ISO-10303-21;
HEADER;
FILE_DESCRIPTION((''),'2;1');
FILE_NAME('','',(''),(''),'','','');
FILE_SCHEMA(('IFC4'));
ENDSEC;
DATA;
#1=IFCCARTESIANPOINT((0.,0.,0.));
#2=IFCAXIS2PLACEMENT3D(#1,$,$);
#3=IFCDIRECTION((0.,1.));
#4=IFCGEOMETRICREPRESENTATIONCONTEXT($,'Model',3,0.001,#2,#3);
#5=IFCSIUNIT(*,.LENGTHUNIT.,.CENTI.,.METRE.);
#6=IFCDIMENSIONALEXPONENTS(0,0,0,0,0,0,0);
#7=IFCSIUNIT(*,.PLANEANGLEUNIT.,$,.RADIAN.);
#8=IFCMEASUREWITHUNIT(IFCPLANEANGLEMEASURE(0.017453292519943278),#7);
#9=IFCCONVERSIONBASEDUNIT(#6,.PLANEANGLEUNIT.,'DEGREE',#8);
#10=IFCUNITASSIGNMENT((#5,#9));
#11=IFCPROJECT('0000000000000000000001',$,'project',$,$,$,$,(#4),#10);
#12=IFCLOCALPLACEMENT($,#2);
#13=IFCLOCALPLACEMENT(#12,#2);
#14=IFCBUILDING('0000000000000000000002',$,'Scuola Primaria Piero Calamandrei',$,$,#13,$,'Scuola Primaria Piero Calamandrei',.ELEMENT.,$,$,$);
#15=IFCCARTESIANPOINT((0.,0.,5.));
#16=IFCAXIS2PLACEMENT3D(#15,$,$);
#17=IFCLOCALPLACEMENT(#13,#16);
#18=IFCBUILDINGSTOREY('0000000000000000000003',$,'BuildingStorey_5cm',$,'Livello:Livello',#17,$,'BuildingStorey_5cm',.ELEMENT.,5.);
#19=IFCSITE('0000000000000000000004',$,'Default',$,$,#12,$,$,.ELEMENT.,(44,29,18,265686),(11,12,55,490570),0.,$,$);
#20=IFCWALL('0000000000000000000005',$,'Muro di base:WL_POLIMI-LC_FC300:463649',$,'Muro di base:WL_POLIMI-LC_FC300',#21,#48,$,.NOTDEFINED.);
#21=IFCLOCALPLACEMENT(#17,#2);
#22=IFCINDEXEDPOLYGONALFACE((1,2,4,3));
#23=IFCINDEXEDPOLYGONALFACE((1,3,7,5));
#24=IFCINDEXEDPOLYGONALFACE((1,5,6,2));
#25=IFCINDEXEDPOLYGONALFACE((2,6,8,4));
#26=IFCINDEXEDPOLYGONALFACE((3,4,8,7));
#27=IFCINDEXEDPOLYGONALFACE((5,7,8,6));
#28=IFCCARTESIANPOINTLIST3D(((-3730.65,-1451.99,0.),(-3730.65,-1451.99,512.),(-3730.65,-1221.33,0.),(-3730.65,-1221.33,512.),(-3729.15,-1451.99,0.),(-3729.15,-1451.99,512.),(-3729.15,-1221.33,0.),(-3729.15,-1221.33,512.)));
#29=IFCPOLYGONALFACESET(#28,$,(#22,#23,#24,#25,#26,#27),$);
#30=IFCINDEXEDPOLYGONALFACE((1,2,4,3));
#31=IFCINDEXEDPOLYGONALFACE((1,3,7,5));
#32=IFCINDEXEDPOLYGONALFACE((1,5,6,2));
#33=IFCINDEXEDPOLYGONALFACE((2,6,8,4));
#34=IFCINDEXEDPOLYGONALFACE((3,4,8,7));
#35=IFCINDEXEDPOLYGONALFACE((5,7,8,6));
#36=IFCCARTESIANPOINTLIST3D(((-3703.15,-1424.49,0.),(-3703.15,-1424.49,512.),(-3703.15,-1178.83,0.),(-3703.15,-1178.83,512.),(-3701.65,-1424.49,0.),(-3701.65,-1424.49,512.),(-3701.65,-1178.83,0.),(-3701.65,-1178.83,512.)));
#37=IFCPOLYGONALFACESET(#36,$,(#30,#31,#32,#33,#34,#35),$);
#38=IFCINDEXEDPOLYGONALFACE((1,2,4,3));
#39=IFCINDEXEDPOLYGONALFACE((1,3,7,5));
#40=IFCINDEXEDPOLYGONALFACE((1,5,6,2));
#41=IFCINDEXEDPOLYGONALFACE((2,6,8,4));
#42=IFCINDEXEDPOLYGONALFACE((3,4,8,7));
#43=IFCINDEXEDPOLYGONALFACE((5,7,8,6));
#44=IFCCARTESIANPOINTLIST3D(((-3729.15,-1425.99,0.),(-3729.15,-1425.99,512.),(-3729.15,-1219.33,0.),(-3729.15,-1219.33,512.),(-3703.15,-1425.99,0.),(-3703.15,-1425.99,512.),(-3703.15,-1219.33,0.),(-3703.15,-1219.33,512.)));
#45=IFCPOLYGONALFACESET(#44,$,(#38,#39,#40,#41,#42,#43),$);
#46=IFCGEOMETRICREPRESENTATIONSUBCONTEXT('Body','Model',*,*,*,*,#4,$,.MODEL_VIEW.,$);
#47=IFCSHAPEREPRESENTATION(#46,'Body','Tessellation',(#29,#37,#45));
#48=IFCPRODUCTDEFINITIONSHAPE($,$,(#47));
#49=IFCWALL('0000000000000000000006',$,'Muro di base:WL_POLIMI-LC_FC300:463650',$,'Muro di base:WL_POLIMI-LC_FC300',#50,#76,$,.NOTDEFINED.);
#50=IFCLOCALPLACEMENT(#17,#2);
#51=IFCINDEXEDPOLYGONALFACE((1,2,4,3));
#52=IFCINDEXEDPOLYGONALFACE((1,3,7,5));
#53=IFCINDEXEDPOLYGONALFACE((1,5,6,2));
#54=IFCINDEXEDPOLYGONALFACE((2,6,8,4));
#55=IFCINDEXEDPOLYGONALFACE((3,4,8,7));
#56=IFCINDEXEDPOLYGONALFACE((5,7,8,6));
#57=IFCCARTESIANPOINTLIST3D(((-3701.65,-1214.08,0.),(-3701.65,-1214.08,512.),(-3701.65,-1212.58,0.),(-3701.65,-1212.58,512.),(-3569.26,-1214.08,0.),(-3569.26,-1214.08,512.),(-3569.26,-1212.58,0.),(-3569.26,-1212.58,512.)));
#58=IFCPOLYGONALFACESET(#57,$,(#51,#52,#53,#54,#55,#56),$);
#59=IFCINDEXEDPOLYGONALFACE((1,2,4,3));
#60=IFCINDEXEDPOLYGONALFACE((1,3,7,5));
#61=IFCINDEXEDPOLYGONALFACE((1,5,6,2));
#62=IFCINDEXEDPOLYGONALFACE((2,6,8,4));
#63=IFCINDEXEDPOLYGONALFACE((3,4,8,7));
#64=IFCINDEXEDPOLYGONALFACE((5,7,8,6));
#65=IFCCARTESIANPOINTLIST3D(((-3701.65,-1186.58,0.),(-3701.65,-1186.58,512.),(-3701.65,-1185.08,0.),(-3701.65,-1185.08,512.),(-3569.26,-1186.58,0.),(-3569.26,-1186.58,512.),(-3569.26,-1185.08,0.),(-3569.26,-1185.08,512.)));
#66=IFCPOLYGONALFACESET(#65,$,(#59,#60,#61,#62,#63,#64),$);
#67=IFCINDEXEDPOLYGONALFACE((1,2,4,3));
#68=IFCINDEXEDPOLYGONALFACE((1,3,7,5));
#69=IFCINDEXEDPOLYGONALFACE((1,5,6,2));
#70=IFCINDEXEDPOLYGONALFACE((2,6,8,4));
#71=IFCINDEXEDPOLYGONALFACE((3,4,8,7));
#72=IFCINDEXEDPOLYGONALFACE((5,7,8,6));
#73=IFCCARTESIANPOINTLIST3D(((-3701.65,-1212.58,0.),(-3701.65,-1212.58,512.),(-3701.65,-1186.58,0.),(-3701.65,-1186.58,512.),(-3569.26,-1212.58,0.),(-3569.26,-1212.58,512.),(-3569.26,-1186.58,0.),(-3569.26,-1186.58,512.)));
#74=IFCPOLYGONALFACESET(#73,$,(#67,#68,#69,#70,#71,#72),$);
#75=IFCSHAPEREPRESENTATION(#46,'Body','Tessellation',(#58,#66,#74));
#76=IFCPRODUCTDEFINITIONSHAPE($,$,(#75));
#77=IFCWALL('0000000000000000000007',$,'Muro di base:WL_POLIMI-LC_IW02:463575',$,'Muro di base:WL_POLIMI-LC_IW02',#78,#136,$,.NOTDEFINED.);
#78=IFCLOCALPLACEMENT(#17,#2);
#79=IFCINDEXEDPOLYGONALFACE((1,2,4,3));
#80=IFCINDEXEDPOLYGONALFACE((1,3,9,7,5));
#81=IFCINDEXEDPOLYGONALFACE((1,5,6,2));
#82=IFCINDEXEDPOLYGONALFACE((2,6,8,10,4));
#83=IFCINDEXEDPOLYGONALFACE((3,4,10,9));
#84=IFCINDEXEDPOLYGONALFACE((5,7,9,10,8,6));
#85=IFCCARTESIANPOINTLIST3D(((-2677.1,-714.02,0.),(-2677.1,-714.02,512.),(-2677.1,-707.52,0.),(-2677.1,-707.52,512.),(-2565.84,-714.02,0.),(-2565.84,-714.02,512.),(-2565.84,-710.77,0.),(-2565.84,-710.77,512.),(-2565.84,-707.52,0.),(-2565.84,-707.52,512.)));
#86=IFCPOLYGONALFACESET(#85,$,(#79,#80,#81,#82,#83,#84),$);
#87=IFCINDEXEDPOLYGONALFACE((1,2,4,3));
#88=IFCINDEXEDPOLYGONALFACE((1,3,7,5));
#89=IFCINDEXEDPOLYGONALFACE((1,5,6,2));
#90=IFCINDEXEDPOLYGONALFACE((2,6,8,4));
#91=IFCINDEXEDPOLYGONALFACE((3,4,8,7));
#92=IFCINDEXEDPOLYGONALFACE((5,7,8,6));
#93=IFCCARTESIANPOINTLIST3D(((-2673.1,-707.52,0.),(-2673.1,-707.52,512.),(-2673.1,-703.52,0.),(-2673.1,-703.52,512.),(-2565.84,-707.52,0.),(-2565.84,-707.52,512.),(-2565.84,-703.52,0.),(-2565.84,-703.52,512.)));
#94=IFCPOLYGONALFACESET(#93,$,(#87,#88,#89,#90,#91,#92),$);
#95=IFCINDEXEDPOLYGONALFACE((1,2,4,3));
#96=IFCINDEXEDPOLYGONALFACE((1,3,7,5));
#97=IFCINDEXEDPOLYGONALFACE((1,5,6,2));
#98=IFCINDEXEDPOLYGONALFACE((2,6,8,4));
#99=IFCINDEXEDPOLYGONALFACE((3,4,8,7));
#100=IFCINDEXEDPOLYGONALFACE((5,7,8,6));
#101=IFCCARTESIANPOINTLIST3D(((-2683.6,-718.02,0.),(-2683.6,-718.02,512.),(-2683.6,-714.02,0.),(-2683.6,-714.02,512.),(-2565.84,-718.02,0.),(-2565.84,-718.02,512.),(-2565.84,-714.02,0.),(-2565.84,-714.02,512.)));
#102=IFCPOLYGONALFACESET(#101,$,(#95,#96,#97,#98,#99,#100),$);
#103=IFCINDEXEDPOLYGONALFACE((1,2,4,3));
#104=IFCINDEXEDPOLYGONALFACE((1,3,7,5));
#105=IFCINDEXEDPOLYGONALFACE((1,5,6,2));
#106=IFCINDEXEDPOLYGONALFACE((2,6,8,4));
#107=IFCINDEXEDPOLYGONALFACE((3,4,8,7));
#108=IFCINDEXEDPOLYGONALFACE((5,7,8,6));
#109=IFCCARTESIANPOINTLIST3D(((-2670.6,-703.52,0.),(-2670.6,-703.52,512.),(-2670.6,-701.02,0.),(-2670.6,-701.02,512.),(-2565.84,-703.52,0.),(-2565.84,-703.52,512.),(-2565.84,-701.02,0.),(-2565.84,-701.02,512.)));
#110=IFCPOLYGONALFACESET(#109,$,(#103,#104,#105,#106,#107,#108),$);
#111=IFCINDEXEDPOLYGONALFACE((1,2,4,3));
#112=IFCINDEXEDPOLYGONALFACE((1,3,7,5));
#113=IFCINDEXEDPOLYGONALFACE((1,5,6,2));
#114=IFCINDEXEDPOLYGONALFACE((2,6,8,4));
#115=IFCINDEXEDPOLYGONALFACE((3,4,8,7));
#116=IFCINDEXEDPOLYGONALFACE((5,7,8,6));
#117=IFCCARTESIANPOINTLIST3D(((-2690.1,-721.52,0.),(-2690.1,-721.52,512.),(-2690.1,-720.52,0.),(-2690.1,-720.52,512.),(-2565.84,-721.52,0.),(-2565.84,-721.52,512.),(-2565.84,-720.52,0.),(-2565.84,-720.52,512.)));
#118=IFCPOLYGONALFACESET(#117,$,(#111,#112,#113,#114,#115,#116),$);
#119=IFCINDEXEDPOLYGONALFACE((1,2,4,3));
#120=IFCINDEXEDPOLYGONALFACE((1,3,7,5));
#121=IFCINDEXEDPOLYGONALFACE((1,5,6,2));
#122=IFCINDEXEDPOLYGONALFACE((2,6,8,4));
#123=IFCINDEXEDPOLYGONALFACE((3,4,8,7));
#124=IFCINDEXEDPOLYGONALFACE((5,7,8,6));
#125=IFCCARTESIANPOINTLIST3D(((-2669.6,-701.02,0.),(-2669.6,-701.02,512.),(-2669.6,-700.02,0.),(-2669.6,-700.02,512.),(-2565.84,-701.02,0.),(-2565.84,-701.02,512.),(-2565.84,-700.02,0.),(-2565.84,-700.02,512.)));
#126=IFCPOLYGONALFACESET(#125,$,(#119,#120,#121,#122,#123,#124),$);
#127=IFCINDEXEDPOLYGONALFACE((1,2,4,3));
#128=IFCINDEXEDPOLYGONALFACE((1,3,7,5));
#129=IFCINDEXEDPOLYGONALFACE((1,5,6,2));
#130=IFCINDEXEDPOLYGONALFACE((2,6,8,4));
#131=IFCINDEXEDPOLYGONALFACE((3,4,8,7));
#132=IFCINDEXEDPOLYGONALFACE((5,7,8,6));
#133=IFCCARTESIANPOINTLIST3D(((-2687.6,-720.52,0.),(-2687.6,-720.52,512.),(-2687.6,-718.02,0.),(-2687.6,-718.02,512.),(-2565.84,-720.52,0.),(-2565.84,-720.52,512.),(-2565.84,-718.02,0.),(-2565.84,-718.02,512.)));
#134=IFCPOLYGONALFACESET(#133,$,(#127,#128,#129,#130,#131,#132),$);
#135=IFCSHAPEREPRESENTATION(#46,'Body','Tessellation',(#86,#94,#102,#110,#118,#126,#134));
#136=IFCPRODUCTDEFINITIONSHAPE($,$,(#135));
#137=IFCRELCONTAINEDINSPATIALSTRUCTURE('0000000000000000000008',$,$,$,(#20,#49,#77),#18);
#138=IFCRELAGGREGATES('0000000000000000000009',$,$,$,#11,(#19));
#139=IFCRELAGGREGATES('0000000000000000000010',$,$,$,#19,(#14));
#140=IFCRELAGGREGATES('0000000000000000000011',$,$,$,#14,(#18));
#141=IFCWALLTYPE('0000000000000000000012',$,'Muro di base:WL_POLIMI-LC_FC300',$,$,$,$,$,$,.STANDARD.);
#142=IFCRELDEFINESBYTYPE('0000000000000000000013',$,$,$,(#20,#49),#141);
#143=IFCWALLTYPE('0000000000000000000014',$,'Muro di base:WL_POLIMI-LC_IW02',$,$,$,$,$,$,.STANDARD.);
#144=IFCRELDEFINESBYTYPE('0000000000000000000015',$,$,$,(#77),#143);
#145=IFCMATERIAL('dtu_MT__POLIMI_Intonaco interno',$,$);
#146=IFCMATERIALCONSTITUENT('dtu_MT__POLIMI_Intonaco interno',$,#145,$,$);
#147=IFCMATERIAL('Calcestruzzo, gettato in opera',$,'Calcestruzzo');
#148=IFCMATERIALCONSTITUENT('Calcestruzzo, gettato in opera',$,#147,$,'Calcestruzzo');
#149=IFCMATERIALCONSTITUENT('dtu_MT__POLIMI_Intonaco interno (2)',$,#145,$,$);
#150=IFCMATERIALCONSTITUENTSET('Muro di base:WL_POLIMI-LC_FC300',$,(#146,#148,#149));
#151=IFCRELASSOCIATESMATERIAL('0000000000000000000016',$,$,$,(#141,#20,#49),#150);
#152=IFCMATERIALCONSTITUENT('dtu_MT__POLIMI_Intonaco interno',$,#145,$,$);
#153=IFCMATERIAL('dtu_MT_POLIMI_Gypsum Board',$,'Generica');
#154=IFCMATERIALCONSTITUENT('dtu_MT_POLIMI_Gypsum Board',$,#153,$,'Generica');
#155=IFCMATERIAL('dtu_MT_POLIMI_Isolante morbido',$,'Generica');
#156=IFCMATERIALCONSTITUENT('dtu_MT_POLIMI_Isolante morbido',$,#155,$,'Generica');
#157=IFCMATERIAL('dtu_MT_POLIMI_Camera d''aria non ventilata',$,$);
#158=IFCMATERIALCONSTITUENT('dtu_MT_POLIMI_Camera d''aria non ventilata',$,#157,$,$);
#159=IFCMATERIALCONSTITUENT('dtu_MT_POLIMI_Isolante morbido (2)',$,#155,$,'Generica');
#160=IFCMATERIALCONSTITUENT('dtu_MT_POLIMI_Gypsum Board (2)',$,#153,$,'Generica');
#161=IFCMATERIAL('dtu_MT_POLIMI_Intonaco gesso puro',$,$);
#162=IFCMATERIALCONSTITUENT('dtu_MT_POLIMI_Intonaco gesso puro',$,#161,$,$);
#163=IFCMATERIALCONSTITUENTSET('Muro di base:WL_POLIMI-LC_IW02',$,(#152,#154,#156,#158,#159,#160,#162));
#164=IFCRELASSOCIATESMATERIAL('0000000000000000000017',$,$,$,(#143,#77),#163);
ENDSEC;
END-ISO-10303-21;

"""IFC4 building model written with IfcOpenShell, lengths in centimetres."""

from ifc_helpers import new_model, entity, si_unit, converted_unit, direction, frame, origin, place, context, subcontext, project, spatial, indexed_curve, outline, extrude, material, constituent, constituent_set, type_object, element, save


model = new_model("IFC4")

# Units and contexts
model_context = context("Model", 3, precision=0.001, world=origin(), true_north=direction((0.0, 1.0)))
body_context = subcontext(model_context, "Body", "Model", "MODEL_VIEW")
ifc_project = project(units=[si_unit("LENGTHUNIT", "METRE", prefix="CENTI"), converted_unit("PLANEANGLEUNIT", "DEGREE", entity("IfcPlaneAngleMeasure", 0.017453292519943278), si_unit("PLANEANGLEUNIT", "RADIAN"), dimensions=[0, 0, 0, 0, 0, 0, 0])], contexts=[model_context])

# Site, building, storey
site_placement = place(None, origin())
site = spatial("IfcSite", under=ifc_project, at=site_placement, Name="Default", CompositionType="ELEMENT", RefLatitude=(44, 29, 18, 265686), RefLongitude=(11, 12, 55, 490570), RefElevation=0.0)
building_placement = place(site_placement, origin())
building = spatial("IfcBuilding", under=site, at=building_placement, Name="Scuola Primaria Piero Calamandrei", LongName="Scuola Primaria Piero Calamandrei", CompositionType="ELEMENT")
storey_placement = place(building_placement, frame((0.0, 0.0, 5.0)))
storey = spatial("IfcBuildingStorey", under=building, at=storey_placement, Name="BuildingStorey_5cm", ObjectType="Livello:Livello", LongName="BuildingStorey_5cm", CompositionType="ELEMENT", Elevation=5.0)

# Shared definitions
ifc_material_1 = material(Name="dtu_MT__POLIMI_Intonaco interno")

# Shared definitions
ifc_material_2 = material(Name="dtu_MT_POLIMI_Intonaco gesso puro")

# Walls
ifc_constituent_1 = constituent(ifc_material_1, Name="dtu_MT__POLIMI_Intonaco interno")
ifc_material_3 = material(Name="Calcestruzzo, gettato in opera", Category="Calcestruzzo")
ifc_constituent_2 = constituent(ifc_material_3, Name="Calcestruzzo, gettato in opera", Category="Calcestruzzo")
ifc_constituent_3 = constituent(ifc_material_1, Name="dtu_MT__POLIMI_Intonaco interno (2)")
ifc_constituent_set_1 = constituent_set(constituents=[ifc_constituent_1, ifc_constituent_2, ifc_constituent_3], Name="Muro di base:WL_POLIMI-LC_FC300")
wall_type_1 = type_object("IfcWallType", Name="Muro di base:WL_POLIMI-LC_FC300", PredefinedType="STANDARD", material=ifc_constituent_set_1)
wall_1_placement = place(storey_placement, frame((-3716.15, -1221.33, 0.0), z_axis=(0.0, 0.0, 1.0), x_axis=(0.0, -1.0, 0.0)))
element("IfcWall", 1, at=wall_1_placement, inside=storey, type_object=wall_type_1, material=ifc_constituent_set_1, Name="Muro di base:WL_POLIMI-LC_FC300:463649", ObjectType="Muro di base:WL_POLIMI-LC_FC300", PredefinedType="NOTDEFINED", context=body_context, shape_type="SweptSolid", body=[
    extrude(outline(indexed_curve([(-0.75, -115.33), (0.75, -115.33), (0.75, 115.33), (-0.75, 115.33), (-0.75, -115.33)], self_intersect=False)), frame((115.33, -13.75, 0.0), z_axis=(0.0, 0.0, 1.0), x_axis=(0.0, 1.0, 0.0)), (0.0, 0.0, 1.0), 512.0),
    extrude(outline(indexed_curve([(-0.75, -122.83), (0.75, -122.83), (0.75, 122.83), (-0.75, 122.83), (-0.75, -122.83)], self_intersect=False)), frame((80.33, 13.75, 0.0), z_axis=(0.0, 0.0, 1.0), x_axis=(0.0, -1.0, 0.0)), (0.0, 0.0, 1.0), 512.0),
    extrude(outline(indexed_curve([(-103.33, -13.0), (103.33, -13.0), (103.33, 13.0), (-103.33, 13.0), (-103.33, -13.0)], self_intersect=False)), frame((101.33, 0.0, 0.0)), (0.0, 0.0, 1.0), 512.0),
])
wall_2_placement = place(storey_placement, frame((-3701.65, -1199.58, 0.0)))
element("IfcWall", 2, at=wall_2_placement, inside=storey, type_object=wall_type_1, material=ifc_constituent_set_1, Name="Muro di base:WL_POLIMI-LC_FC300:463650", ObjectType="Muro di base:WL_POLIMI-LC_FC300", PredefinedType="NOTDEFINED", context=body_context, shape_type="SweptSolid", body=[
    extrude(outline(indexed_curve([(-0.75, -66.2), (0.75, -66.2), (0.75, 66.2), (-0.75, 66.2), (-0.75, -66.2)], self_intersect=False)), frame((66.2, -13.75, 0.0), z_axis=(0.0, 0.0, 1.0), x_axis=(0.0, 1.0, 0.0)), (0.0, 0.0, 1.0), 512.0),
    extrude(outline(indexed_curve([(-0.75, -66.2), (0.75, -66.2), (0.75, 66.2), (-0.75, 66.2), (-0.75, -66.2)], self_intersect=False)), frame((66.2, 13.75, 0.0), z_axis=(0.0, 0.0, 1.0), x_axis=(0.0, -1.0, 0.0)), (0.0, 0.0, 1.0), 512.0),
    extrude(outline(indexed_curve([(-66.2, -13.0), (66.2, -13.0), (66.2, 13.0), (-66.2, 13.0), (-66.2, -13.0)], self_intersect=False)), frame((66.2, 0.0, 0.0)), (0.0, 0.0, 1.0), 512.0),
])

# Shared definitions
ifc_material_4 = material(Name="dtu_MT_POLIMI_Isolante morbido", Category="Generica")
ifc_material_5 = material(Name="dtu_MT_POLIMI_Gypsum Board", Category="Generica")
ifc_constituent_4 = constituent(ifc_material_1, Name="dtu_MT__POLIMI_Intonaco interno")
ifc_constituent_5 = constituent(ifc_material_5, Name="dtu_MT_POLIMI_Gypsum Board", Category="Generica")
ifc_constituent_6 = constituent(ifc_material_4, Name="dtu_MT_POLIMI_Isolante morbido", Category="Generica")
ifc_material_6 = material(Name="dtu_MT_POLIMI_Camera d'aria non ventilata")
ifc_constituent_7 = constituent(ifc_material_6, Name="dtu_MT_POLIMI_Camera d'aria non ventilata")
ifc_constituent_8 = constituent(ifc_material_4, Name="dtu_MT_POLIMI_Isolante morbido (2)", Category="Generica")
ifc_constituent_9 = constituent(ifc_material_5, Name="dtu_MT_POLIMI_Gypsum Board (2)", Category="Generica")
ifc_constituent_10 = constituent(ifc_material_2, Name="dtu_MT_POLIMI_Intonaco gesso puro")
ifc_constituent_set_2 = constituent_set(constituents=[ifc_constituent_4, ifc_constituent_5, ifc_constituent_6, ifc_constituent_7, ifc_constituent_8, ifc_constituent_9, ifc_constituent_10], Name="Muro di base:WL_POLIMI-LC_IW02")
wall_type_2 = type_object("IfcWallType", Name="Muro di base:WL_POLIMI-LC_IW02", PredefinedType="STANDARD", material=ifc_constituent_set_2)

# Wall
wall_3_placement = place(storey_placement, frame((-2669.6, -710.77, 0.0)))
element("IfcWall", 3, at=wall_3_placement, inside=storey, type_object=wall_type_2, material=ifc_constituent_set_2, Name="Muro di base:WL_POLIMI-LC_IW02:463575", ObjectType="Muro di base:WL_POLIMI-LC_IW02", PredefinedType="NOTDEFINED", context=body_context, shape_type="SweptSolid", body=[
    extrude(outline(indexed_curve([(-66.76, -3.25), (44.51, -3.25), (44.51, 0.0), (44.51, 3.25), (-66.76, 3.25), (-66.76, -3.25)], self_intersect=False)), frame((59.26, 0.0, 0.0)), (0.0, 0.0, 1.0), 512.0),
    extrude(outline(indexed_curve([(-53.63, -2.0), (53.63, -2.0), (53.63, 2.0), (-53.63, 2.0), (-53.63, -2.0)], self_intersect=False)), frame((50.13, 5.25, 0.0)), (0.0, 0.0, 1.0), 512.0),
    extrude(outline(indexed_curve([(-58.88, -2.0), (58.88, -2.0), (58.88, 2.0), (-58.88, 2.0), (-58.88, -2.0)], self_intersect=False)), frame((44.88, -5.25, 0.0)), (0.0, 0.0, 1.0), 512.0),
    extrude(outline(indexed_curve([(-52.38, -1.25), (52.38, -1.25), (52.38, 1.25), (-52.38, 1.25), (-52.38, -1.25)], self_intersect=False)), frame((51.38, 8.5, 0.0)), (0.0, 0.0, 1.0), 512.0),
    extrude(outline(indexed_curve([(-0.5, -62.13), (0.5, -62.13), (0.5, 62.13), (-0.5, 62.13), (-0.5, -62.13)], self_intersect=False)), frame((41.63, -10.25, 0.0), z_axis=(0.0, 0.0, 1.0), x_axis=(0.0, 1.0, 0.0)), (0.0, 0.0, 1.0), 512.0),
    extrude(outline(indexed_curve([(-0.5, -51.88), (0.5, -51.88), (0.5, 51.88), (-0.5, 51.88), (-0.5, -51.88)], self_intersect=False)), frame((51.88, 10.25, 0.0), z_axis=(0.0, 0.0, 1.0), x_axis=(0.0, -1.0, 0.0)), (0.0, 0.0, 1.0), 512.0),
    extrude(outline(indexed_curve([(-60.88, -1.25), (60.88, -1.25), (60.88, 1.25), (-60.88, 1.25), (-60.88, -1.25)], self_intersect=False)), frame((42.88, -8.5, 0.0)), (0.0, 0.0, 1.0), 512.0),
])

save(model, "model.ifc")
